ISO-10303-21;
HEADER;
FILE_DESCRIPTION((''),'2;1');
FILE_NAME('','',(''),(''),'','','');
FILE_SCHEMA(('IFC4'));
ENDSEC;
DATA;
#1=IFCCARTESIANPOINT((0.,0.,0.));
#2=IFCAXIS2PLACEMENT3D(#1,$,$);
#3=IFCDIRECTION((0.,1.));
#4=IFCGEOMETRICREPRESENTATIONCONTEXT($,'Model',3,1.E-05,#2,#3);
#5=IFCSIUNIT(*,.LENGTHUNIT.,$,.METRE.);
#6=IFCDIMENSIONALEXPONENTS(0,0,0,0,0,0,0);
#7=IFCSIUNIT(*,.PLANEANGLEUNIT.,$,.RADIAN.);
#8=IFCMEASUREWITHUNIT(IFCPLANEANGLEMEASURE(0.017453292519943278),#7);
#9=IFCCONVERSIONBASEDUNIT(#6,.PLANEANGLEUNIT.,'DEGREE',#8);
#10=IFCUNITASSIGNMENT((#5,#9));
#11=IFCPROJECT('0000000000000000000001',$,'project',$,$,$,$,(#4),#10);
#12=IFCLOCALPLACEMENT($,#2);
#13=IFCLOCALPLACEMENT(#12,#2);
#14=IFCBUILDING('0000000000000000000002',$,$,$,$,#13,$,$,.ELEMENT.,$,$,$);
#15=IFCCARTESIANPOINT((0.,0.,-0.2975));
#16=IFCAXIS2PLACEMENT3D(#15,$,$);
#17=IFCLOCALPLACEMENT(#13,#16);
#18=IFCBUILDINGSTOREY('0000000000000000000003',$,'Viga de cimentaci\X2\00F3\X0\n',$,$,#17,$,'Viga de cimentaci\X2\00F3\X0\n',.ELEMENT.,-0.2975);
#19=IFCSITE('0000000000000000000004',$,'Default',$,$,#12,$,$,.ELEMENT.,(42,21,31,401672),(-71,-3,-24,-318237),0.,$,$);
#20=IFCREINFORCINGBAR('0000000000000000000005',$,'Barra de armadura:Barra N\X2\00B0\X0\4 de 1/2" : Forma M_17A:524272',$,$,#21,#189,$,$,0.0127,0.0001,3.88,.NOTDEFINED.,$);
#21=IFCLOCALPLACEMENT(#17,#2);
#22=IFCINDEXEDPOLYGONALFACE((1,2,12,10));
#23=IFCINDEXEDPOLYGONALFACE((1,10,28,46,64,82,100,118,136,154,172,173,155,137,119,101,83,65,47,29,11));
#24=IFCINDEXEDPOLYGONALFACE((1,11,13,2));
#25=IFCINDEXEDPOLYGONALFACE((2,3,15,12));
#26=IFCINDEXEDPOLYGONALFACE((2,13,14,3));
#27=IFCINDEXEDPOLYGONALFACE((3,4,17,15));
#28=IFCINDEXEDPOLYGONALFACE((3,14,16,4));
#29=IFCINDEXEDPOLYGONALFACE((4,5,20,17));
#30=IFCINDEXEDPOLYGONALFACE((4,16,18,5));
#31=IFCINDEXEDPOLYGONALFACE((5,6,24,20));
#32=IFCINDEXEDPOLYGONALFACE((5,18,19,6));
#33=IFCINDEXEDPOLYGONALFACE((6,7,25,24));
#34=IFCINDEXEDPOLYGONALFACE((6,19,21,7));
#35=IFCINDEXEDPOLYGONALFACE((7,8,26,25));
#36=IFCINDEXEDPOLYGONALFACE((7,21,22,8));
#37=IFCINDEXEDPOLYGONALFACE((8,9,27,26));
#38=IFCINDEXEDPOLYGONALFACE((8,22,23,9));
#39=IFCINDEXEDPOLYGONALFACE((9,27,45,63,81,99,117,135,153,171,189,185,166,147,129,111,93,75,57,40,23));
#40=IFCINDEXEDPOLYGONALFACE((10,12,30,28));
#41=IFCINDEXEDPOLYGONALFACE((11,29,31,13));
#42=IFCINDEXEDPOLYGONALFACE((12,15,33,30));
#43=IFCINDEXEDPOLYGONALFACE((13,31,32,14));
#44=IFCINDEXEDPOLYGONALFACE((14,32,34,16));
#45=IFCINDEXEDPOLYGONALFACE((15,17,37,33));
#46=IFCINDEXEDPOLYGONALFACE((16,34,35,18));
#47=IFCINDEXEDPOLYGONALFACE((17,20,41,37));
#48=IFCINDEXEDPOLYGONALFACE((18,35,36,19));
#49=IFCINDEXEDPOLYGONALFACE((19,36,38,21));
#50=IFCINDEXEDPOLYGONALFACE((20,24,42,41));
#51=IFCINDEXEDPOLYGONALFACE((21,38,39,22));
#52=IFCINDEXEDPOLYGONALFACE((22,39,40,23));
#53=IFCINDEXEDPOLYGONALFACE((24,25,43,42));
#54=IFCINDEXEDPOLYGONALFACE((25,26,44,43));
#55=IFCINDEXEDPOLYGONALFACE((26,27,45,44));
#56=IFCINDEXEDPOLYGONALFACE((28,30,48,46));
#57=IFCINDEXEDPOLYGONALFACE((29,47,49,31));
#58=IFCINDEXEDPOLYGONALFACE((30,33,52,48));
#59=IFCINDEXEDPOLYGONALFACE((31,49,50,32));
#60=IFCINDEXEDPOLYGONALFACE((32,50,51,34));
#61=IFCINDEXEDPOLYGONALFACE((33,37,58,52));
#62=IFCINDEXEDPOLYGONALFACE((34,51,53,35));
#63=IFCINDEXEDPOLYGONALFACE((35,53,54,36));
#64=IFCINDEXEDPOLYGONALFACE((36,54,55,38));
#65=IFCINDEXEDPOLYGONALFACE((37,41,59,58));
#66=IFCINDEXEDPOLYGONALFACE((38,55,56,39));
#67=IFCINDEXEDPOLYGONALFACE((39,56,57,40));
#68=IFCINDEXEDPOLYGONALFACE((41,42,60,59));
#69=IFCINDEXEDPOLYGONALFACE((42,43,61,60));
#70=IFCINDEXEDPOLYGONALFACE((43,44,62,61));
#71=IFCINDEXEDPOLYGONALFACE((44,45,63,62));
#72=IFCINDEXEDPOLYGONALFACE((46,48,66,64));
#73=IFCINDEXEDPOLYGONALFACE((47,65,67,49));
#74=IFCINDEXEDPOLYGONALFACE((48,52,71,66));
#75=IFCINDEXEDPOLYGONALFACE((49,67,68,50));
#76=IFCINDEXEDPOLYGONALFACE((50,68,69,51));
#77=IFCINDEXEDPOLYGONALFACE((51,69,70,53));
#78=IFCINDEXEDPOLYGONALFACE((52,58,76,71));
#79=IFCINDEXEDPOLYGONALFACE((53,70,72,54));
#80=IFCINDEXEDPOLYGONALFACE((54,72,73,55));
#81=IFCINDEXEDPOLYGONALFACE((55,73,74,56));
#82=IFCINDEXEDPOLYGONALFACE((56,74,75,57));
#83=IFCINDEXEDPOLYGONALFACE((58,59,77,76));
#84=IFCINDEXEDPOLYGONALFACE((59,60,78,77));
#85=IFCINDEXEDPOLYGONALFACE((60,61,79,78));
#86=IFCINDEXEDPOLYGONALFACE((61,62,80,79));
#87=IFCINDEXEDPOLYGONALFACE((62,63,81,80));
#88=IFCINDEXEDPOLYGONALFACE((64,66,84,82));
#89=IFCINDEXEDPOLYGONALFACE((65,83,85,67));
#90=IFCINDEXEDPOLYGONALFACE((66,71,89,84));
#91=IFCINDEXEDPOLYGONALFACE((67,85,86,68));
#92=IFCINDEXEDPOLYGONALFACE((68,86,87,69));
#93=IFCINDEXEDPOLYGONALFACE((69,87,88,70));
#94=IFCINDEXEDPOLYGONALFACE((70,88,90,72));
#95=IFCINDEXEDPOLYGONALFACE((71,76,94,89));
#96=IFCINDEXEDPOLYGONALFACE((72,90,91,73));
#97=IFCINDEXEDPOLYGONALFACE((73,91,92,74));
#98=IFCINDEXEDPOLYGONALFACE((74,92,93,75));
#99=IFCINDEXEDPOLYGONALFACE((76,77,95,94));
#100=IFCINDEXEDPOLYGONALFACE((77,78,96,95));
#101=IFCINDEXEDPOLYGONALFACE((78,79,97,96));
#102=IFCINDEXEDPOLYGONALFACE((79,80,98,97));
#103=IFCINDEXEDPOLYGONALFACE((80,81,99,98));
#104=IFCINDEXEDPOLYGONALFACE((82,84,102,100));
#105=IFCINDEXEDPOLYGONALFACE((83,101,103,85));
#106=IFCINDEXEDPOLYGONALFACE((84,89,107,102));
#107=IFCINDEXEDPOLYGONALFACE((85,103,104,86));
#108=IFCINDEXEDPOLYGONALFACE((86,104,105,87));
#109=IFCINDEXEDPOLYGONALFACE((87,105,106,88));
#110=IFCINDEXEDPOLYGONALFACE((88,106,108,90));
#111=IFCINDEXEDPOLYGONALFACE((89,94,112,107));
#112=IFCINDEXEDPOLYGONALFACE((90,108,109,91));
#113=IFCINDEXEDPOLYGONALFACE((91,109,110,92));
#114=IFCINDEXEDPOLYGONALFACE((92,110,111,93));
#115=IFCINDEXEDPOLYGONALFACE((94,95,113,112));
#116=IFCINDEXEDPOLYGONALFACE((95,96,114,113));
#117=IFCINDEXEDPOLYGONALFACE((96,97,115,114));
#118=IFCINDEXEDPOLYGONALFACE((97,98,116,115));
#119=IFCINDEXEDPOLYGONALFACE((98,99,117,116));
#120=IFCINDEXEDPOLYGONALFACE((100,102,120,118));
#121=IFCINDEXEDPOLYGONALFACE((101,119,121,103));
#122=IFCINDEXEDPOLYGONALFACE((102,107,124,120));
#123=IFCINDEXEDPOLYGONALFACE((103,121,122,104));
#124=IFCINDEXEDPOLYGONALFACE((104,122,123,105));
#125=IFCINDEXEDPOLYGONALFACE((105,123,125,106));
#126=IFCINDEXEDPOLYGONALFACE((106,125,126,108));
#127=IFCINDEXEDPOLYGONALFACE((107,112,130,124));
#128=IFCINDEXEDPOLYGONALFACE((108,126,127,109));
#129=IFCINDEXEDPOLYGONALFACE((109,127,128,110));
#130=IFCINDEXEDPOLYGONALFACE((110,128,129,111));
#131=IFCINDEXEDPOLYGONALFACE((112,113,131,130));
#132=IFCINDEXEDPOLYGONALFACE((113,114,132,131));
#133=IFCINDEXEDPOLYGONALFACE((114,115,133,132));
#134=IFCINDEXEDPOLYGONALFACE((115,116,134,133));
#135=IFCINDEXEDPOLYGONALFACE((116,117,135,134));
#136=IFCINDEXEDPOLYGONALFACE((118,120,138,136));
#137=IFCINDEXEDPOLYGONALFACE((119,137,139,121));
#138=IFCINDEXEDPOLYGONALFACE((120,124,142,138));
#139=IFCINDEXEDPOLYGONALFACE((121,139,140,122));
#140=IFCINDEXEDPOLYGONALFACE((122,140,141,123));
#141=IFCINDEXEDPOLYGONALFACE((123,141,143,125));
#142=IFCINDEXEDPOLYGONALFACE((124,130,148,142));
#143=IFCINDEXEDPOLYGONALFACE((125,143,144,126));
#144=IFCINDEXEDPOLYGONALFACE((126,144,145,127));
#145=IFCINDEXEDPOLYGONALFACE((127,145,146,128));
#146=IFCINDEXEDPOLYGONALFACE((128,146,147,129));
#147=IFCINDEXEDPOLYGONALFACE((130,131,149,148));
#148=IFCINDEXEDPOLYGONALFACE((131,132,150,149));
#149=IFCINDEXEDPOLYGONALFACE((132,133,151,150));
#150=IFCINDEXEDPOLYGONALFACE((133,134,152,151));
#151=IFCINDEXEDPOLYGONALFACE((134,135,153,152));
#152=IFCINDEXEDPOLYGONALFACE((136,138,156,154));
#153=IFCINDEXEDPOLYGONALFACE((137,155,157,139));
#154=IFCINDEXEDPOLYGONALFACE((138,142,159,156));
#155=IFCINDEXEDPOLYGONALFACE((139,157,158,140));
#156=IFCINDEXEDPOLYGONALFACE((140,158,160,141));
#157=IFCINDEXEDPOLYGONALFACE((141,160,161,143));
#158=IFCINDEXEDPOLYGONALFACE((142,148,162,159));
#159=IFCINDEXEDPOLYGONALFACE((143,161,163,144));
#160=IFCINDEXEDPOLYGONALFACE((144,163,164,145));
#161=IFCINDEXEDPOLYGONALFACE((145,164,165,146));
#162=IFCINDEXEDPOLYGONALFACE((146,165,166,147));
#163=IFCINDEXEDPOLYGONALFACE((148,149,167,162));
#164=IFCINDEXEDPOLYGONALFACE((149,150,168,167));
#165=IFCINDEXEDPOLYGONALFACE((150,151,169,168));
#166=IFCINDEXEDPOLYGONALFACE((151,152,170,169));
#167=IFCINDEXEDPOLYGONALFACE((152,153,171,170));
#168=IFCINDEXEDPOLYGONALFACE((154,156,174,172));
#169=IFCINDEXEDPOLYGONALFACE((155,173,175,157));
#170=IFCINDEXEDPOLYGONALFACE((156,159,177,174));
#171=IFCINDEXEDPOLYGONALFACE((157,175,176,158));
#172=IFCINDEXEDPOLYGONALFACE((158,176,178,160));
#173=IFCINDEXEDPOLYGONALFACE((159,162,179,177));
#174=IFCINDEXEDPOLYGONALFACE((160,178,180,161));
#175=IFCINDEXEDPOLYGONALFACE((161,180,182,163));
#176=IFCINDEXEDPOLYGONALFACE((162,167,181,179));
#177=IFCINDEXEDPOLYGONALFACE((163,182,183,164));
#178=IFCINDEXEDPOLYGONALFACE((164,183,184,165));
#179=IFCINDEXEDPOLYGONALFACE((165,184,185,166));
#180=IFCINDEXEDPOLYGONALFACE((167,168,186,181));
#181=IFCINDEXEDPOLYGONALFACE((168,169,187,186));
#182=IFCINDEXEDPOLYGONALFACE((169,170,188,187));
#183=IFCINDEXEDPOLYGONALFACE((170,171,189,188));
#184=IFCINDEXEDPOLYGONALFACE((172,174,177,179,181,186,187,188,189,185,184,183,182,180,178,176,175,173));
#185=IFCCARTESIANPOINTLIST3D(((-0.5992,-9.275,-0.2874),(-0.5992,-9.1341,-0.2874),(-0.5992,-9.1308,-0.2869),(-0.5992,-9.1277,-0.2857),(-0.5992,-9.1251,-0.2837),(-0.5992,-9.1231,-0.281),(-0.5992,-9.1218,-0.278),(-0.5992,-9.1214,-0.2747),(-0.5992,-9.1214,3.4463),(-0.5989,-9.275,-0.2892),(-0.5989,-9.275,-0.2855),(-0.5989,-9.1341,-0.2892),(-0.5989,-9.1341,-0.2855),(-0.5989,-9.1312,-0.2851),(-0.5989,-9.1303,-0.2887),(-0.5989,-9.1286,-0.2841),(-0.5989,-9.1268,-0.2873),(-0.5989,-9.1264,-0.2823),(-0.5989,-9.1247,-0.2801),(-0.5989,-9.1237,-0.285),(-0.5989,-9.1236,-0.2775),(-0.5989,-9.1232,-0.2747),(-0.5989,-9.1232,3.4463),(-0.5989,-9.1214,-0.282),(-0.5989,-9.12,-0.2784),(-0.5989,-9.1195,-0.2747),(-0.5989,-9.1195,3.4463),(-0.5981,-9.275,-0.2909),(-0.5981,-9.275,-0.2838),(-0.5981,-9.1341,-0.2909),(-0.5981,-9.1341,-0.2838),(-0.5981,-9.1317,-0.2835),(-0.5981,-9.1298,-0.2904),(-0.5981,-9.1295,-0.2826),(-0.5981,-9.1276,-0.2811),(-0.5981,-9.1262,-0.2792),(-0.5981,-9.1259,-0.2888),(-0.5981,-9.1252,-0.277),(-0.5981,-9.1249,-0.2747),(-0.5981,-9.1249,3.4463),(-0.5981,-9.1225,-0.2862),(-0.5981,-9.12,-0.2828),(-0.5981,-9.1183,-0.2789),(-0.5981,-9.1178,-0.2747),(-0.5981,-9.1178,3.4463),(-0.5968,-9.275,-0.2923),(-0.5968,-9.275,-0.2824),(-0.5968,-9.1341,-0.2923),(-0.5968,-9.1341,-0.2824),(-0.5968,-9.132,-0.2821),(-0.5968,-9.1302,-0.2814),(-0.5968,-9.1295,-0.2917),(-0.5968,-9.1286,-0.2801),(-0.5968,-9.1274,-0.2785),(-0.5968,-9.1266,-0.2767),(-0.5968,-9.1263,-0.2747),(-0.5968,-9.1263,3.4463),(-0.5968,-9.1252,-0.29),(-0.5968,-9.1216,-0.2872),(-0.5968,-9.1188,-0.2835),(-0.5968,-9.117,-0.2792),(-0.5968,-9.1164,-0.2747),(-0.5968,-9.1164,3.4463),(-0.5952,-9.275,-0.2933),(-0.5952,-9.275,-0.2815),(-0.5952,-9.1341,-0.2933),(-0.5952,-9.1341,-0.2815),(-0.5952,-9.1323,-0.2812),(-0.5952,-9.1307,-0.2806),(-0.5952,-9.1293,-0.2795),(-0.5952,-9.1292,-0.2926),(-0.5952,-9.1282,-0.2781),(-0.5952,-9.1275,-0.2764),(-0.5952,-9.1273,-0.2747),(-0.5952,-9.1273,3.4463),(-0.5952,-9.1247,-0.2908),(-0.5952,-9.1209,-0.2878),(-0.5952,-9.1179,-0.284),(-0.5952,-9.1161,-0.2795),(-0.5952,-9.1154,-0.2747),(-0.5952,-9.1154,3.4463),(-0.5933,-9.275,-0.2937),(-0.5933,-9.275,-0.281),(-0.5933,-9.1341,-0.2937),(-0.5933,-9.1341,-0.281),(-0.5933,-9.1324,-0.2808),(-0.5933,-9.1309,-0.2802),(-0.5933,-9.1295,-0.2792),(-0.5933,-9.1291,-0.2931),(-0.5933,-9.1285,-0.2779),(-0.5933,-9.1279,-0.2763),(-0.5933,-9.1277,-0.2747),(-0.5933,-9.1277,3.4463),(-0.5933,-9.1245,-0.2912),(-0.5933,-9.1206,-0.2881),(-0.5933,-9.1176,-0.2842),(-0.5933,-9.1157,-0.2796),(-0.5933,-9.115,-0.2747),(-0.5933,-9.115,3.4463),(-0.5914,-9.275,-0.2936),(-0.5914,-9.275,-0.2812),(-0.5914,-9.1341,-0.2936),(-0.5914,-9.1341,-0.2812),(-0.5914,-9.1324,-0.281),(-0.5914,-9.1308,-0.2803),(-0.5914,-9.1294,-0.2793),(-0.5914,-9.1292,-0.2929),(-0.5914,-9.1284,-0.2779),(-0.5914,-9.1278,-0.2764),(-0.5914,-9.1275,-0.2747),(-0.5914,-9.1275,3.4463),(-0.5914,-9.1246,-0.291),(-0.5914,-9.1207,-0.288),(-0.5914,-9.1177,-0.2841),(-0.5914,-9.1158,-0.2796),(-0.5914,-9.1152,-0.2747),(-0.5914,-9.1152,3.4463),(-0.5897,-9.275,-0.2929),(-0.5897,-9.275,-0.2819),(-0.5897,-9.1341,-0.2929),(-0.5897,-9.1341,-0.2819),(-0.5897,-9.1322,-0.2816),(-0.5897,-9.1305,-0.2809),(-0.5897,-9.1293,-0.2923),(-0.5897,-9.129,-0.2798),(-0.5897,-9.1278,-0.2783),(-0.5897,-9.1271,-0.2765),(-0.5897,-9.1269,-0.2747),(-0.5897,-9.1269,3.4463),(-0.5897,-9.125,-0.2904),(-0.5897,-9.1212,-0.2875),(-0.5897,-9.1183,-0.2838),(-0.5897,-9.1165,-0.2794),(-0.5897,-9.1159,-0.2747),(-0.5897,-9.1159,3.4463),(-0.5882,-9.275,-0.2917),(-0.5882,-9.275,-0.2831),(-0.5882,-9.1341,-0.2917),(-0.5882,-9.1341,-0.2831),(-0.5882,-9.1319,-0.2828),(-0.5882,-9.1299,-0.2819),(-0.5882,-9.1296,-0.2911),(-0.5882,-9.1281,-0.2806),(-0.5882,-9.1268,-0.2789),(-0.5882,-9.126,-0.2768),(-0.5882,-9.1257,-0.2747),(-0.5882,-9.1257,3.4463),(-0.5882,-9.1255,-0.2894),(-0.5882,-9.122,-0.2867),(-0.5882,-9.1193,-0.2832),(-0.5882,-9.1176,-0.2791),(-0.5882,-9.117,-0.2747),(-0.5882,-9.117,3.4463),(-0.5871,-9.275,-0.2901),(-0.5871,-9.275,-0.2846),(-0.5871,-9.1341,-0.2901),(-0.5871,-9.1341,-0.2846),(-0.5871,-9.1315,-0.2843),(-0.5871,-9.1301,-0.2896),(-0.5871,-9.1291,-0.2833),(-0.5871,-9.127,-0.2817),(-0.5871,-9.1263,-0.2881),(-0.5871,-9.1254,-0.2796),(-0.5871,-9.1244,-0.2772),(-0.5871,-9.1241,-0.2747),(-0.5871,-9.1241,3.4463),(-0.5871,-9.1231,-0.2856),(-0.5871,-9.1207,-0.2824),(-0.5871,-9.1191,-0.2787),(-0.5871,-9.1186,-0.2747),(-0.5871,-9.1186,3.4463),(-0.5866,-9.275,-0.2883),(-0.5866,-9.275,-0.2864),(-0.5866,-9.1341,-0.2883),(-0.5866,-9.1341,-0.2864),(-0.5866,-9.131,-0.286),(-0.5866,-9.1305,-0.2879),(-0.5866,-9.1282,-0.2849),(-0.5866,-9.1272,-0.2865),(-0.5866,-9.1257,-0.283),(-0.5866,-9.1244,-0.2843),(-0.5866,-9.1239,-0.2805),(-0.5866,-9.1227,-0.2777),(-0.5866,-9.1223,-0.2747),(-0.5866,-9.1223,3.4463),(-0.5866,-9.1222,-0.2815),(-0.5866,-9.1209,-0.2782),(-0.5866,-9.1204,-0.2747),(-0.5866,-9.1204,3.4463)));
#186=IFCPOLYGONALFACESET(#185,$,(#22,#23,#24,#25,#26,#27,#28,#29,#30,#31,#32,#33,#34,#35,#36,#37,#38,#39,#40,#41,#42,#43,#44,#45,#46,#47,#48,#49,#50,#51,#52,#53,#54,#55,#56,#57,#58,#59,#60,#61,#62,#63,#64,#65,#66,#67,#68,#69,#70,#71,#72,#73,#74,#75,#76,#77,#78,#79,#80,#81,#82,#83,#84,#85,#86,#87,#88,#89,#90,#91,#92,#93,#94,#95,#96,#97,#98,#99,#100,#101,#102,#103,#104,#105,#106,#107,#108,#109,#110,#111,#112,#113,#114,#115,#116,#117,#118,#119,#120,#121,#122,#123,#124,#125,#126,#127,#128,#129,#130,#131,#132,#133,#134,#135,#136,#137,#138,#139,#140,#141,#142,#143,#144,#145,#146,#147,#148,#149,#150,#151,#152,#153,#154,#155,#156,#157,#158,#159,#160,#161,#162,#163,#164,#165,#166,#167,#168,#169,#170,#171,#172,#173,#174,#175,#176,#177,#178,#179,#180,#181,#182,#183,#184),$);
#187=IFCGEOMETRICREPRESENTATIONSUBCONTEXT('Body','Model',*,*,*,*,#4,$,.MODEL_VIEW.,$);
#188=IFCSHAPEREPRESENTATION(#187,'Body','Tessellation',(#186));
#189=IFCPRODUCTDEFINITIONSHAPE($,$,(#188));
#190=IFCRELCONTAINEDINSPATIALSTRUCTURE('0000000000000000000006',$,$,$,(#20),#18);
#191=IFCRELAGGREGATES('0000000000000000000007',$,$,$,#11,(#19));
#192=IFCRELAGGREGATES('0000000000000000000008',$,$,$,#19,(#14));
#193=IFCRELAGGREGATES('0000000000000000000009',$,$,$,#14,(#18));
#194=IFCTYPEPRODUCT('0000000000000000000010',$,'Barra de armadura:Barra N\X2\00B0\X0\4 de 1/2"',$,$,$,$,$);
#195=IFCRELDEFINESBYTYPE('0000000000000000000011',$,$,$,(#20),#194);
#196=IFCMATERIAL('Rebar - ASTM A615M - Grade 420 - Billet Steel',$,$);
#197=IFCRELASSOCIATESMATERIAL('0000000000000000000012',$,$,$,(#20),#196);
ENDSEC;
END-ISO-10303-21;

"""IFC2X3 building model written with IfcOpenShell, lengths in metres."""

from ifc_helpers import new_model, entity, si_unit, converted_unit, direction, frame, origin, place, context, subcontext, project, spatial, material, type_object, element, save


model = new_model("IFC2X3")

# Units and contexts
model_context = context("Model", 3, precision=1e-05, world=origin(), true_north=direction((0.0, 1.0)))
body_context = subcontext(model_context, "Body", "Model", "MODEL_VIEW")
ifc_project = project(units=[si_unit("LENGTHUNIT", "METRE"), converted_unit("PLANEANGLEUNIT", "DEGREE", entity("IfcPlaneAngleMeasure", 0.017453292519943278), si_unit("PLANEANGLEUNIT", "RADIAN"), dimensions=[0, 0, 0, 0, 0, 0, 0])], contexts=[model_context])

# Site, building, storey
site_placement = place(None, origin())
site = spatial("IfcSite", under=ifc_project, at=site_placement, Name="Default", CompositionType="ELEMENT", RefLatitude=(42, 21, 31, 401672), RefLongitude=(-71, -3, -24, -318237), RefElevation=0.0)
building_placement = place(site_placement, origin())
building = spatial("IfcBuilding", under=site, at=building_placement, CompositionType="ELEMENT")
storey_placement = place(building_placement, frame((0.0, 0.0, -0.2975)))
storey = spatial("IfcBuildingStorey", under=building, at=storey_placement, Name="Viga de cimentación", LongName="Viga de cimentación", CompositionType="ELEMENT", Elevation=-0.2975)

# Reinforcing bar
ifc_material = material(Name="Rebar - ASTM A615M - Grade 420 - Billet Steel")
type_product_1 = type_object("IfcTypeProduct", Name="Barra de armadura:Barra N°4 de 1/2\"")
reinforcing_bar_1_placement = place(storey_placement, origin())
element("IfcReinforcingBar", 1, at=reinforcing_bar_1_placement, inside=storey, type_object=type_product_1, material=ifc_material, Name="Barra de armadura:Barra N°4 de 1/2\" : Forma M_17A:524272", BarLength=3.88, BarRole="NOTDEFINED", CrossSectionArea=0.0001, NominalDiameter=0.0127, context=body_context, shape_type="AdvancedSweptSolid", body=[
    entity("IfcSweptDiskSolid", entity("IfcCompositeCurve", [entity("IfcCompositeCurveSegment", "CONTINUOUS", True, entity("IfcPolyline", [entity("IfcCartesianPoint", [-0.5929, -9.1214, 3.4463]), entity("IfcCartesianPoint", [-0.5929, -9.1214, -0.2747])])), entity("IfcCompositeCurveSegment", "CONTINUOUS", True, entity("IfcTrimmedCurve", entity("IfcCircle", entity("IfcAxis2Placement3D", entity("IfcCartesianPoint", [-0.5929, -9.1341, -0.2747]), entity("IfcDirection", [-1.0, 0.0, 0.0]), entity("IfcDirection", [0.0, 0.0, -1.0])), 0.0127), [entity("IfcParameterValue", 270.0)], [entity("IfcParameterValue", 360.0)], True, "PARAMETER")), entity("IfcCompositeCurveSegment", "CONTINUOUS", True, entity("IfcPolyline", [entity("IfcCartesianPoint", [-0.5929, -9.1341, -0.2874]), entity("IfcCartesianPoint", [-0.5929, -9.275, -0.2874])]))], False), 0.0063, None, 0.0, 92.0),
])

save(model, "model.ifc")
